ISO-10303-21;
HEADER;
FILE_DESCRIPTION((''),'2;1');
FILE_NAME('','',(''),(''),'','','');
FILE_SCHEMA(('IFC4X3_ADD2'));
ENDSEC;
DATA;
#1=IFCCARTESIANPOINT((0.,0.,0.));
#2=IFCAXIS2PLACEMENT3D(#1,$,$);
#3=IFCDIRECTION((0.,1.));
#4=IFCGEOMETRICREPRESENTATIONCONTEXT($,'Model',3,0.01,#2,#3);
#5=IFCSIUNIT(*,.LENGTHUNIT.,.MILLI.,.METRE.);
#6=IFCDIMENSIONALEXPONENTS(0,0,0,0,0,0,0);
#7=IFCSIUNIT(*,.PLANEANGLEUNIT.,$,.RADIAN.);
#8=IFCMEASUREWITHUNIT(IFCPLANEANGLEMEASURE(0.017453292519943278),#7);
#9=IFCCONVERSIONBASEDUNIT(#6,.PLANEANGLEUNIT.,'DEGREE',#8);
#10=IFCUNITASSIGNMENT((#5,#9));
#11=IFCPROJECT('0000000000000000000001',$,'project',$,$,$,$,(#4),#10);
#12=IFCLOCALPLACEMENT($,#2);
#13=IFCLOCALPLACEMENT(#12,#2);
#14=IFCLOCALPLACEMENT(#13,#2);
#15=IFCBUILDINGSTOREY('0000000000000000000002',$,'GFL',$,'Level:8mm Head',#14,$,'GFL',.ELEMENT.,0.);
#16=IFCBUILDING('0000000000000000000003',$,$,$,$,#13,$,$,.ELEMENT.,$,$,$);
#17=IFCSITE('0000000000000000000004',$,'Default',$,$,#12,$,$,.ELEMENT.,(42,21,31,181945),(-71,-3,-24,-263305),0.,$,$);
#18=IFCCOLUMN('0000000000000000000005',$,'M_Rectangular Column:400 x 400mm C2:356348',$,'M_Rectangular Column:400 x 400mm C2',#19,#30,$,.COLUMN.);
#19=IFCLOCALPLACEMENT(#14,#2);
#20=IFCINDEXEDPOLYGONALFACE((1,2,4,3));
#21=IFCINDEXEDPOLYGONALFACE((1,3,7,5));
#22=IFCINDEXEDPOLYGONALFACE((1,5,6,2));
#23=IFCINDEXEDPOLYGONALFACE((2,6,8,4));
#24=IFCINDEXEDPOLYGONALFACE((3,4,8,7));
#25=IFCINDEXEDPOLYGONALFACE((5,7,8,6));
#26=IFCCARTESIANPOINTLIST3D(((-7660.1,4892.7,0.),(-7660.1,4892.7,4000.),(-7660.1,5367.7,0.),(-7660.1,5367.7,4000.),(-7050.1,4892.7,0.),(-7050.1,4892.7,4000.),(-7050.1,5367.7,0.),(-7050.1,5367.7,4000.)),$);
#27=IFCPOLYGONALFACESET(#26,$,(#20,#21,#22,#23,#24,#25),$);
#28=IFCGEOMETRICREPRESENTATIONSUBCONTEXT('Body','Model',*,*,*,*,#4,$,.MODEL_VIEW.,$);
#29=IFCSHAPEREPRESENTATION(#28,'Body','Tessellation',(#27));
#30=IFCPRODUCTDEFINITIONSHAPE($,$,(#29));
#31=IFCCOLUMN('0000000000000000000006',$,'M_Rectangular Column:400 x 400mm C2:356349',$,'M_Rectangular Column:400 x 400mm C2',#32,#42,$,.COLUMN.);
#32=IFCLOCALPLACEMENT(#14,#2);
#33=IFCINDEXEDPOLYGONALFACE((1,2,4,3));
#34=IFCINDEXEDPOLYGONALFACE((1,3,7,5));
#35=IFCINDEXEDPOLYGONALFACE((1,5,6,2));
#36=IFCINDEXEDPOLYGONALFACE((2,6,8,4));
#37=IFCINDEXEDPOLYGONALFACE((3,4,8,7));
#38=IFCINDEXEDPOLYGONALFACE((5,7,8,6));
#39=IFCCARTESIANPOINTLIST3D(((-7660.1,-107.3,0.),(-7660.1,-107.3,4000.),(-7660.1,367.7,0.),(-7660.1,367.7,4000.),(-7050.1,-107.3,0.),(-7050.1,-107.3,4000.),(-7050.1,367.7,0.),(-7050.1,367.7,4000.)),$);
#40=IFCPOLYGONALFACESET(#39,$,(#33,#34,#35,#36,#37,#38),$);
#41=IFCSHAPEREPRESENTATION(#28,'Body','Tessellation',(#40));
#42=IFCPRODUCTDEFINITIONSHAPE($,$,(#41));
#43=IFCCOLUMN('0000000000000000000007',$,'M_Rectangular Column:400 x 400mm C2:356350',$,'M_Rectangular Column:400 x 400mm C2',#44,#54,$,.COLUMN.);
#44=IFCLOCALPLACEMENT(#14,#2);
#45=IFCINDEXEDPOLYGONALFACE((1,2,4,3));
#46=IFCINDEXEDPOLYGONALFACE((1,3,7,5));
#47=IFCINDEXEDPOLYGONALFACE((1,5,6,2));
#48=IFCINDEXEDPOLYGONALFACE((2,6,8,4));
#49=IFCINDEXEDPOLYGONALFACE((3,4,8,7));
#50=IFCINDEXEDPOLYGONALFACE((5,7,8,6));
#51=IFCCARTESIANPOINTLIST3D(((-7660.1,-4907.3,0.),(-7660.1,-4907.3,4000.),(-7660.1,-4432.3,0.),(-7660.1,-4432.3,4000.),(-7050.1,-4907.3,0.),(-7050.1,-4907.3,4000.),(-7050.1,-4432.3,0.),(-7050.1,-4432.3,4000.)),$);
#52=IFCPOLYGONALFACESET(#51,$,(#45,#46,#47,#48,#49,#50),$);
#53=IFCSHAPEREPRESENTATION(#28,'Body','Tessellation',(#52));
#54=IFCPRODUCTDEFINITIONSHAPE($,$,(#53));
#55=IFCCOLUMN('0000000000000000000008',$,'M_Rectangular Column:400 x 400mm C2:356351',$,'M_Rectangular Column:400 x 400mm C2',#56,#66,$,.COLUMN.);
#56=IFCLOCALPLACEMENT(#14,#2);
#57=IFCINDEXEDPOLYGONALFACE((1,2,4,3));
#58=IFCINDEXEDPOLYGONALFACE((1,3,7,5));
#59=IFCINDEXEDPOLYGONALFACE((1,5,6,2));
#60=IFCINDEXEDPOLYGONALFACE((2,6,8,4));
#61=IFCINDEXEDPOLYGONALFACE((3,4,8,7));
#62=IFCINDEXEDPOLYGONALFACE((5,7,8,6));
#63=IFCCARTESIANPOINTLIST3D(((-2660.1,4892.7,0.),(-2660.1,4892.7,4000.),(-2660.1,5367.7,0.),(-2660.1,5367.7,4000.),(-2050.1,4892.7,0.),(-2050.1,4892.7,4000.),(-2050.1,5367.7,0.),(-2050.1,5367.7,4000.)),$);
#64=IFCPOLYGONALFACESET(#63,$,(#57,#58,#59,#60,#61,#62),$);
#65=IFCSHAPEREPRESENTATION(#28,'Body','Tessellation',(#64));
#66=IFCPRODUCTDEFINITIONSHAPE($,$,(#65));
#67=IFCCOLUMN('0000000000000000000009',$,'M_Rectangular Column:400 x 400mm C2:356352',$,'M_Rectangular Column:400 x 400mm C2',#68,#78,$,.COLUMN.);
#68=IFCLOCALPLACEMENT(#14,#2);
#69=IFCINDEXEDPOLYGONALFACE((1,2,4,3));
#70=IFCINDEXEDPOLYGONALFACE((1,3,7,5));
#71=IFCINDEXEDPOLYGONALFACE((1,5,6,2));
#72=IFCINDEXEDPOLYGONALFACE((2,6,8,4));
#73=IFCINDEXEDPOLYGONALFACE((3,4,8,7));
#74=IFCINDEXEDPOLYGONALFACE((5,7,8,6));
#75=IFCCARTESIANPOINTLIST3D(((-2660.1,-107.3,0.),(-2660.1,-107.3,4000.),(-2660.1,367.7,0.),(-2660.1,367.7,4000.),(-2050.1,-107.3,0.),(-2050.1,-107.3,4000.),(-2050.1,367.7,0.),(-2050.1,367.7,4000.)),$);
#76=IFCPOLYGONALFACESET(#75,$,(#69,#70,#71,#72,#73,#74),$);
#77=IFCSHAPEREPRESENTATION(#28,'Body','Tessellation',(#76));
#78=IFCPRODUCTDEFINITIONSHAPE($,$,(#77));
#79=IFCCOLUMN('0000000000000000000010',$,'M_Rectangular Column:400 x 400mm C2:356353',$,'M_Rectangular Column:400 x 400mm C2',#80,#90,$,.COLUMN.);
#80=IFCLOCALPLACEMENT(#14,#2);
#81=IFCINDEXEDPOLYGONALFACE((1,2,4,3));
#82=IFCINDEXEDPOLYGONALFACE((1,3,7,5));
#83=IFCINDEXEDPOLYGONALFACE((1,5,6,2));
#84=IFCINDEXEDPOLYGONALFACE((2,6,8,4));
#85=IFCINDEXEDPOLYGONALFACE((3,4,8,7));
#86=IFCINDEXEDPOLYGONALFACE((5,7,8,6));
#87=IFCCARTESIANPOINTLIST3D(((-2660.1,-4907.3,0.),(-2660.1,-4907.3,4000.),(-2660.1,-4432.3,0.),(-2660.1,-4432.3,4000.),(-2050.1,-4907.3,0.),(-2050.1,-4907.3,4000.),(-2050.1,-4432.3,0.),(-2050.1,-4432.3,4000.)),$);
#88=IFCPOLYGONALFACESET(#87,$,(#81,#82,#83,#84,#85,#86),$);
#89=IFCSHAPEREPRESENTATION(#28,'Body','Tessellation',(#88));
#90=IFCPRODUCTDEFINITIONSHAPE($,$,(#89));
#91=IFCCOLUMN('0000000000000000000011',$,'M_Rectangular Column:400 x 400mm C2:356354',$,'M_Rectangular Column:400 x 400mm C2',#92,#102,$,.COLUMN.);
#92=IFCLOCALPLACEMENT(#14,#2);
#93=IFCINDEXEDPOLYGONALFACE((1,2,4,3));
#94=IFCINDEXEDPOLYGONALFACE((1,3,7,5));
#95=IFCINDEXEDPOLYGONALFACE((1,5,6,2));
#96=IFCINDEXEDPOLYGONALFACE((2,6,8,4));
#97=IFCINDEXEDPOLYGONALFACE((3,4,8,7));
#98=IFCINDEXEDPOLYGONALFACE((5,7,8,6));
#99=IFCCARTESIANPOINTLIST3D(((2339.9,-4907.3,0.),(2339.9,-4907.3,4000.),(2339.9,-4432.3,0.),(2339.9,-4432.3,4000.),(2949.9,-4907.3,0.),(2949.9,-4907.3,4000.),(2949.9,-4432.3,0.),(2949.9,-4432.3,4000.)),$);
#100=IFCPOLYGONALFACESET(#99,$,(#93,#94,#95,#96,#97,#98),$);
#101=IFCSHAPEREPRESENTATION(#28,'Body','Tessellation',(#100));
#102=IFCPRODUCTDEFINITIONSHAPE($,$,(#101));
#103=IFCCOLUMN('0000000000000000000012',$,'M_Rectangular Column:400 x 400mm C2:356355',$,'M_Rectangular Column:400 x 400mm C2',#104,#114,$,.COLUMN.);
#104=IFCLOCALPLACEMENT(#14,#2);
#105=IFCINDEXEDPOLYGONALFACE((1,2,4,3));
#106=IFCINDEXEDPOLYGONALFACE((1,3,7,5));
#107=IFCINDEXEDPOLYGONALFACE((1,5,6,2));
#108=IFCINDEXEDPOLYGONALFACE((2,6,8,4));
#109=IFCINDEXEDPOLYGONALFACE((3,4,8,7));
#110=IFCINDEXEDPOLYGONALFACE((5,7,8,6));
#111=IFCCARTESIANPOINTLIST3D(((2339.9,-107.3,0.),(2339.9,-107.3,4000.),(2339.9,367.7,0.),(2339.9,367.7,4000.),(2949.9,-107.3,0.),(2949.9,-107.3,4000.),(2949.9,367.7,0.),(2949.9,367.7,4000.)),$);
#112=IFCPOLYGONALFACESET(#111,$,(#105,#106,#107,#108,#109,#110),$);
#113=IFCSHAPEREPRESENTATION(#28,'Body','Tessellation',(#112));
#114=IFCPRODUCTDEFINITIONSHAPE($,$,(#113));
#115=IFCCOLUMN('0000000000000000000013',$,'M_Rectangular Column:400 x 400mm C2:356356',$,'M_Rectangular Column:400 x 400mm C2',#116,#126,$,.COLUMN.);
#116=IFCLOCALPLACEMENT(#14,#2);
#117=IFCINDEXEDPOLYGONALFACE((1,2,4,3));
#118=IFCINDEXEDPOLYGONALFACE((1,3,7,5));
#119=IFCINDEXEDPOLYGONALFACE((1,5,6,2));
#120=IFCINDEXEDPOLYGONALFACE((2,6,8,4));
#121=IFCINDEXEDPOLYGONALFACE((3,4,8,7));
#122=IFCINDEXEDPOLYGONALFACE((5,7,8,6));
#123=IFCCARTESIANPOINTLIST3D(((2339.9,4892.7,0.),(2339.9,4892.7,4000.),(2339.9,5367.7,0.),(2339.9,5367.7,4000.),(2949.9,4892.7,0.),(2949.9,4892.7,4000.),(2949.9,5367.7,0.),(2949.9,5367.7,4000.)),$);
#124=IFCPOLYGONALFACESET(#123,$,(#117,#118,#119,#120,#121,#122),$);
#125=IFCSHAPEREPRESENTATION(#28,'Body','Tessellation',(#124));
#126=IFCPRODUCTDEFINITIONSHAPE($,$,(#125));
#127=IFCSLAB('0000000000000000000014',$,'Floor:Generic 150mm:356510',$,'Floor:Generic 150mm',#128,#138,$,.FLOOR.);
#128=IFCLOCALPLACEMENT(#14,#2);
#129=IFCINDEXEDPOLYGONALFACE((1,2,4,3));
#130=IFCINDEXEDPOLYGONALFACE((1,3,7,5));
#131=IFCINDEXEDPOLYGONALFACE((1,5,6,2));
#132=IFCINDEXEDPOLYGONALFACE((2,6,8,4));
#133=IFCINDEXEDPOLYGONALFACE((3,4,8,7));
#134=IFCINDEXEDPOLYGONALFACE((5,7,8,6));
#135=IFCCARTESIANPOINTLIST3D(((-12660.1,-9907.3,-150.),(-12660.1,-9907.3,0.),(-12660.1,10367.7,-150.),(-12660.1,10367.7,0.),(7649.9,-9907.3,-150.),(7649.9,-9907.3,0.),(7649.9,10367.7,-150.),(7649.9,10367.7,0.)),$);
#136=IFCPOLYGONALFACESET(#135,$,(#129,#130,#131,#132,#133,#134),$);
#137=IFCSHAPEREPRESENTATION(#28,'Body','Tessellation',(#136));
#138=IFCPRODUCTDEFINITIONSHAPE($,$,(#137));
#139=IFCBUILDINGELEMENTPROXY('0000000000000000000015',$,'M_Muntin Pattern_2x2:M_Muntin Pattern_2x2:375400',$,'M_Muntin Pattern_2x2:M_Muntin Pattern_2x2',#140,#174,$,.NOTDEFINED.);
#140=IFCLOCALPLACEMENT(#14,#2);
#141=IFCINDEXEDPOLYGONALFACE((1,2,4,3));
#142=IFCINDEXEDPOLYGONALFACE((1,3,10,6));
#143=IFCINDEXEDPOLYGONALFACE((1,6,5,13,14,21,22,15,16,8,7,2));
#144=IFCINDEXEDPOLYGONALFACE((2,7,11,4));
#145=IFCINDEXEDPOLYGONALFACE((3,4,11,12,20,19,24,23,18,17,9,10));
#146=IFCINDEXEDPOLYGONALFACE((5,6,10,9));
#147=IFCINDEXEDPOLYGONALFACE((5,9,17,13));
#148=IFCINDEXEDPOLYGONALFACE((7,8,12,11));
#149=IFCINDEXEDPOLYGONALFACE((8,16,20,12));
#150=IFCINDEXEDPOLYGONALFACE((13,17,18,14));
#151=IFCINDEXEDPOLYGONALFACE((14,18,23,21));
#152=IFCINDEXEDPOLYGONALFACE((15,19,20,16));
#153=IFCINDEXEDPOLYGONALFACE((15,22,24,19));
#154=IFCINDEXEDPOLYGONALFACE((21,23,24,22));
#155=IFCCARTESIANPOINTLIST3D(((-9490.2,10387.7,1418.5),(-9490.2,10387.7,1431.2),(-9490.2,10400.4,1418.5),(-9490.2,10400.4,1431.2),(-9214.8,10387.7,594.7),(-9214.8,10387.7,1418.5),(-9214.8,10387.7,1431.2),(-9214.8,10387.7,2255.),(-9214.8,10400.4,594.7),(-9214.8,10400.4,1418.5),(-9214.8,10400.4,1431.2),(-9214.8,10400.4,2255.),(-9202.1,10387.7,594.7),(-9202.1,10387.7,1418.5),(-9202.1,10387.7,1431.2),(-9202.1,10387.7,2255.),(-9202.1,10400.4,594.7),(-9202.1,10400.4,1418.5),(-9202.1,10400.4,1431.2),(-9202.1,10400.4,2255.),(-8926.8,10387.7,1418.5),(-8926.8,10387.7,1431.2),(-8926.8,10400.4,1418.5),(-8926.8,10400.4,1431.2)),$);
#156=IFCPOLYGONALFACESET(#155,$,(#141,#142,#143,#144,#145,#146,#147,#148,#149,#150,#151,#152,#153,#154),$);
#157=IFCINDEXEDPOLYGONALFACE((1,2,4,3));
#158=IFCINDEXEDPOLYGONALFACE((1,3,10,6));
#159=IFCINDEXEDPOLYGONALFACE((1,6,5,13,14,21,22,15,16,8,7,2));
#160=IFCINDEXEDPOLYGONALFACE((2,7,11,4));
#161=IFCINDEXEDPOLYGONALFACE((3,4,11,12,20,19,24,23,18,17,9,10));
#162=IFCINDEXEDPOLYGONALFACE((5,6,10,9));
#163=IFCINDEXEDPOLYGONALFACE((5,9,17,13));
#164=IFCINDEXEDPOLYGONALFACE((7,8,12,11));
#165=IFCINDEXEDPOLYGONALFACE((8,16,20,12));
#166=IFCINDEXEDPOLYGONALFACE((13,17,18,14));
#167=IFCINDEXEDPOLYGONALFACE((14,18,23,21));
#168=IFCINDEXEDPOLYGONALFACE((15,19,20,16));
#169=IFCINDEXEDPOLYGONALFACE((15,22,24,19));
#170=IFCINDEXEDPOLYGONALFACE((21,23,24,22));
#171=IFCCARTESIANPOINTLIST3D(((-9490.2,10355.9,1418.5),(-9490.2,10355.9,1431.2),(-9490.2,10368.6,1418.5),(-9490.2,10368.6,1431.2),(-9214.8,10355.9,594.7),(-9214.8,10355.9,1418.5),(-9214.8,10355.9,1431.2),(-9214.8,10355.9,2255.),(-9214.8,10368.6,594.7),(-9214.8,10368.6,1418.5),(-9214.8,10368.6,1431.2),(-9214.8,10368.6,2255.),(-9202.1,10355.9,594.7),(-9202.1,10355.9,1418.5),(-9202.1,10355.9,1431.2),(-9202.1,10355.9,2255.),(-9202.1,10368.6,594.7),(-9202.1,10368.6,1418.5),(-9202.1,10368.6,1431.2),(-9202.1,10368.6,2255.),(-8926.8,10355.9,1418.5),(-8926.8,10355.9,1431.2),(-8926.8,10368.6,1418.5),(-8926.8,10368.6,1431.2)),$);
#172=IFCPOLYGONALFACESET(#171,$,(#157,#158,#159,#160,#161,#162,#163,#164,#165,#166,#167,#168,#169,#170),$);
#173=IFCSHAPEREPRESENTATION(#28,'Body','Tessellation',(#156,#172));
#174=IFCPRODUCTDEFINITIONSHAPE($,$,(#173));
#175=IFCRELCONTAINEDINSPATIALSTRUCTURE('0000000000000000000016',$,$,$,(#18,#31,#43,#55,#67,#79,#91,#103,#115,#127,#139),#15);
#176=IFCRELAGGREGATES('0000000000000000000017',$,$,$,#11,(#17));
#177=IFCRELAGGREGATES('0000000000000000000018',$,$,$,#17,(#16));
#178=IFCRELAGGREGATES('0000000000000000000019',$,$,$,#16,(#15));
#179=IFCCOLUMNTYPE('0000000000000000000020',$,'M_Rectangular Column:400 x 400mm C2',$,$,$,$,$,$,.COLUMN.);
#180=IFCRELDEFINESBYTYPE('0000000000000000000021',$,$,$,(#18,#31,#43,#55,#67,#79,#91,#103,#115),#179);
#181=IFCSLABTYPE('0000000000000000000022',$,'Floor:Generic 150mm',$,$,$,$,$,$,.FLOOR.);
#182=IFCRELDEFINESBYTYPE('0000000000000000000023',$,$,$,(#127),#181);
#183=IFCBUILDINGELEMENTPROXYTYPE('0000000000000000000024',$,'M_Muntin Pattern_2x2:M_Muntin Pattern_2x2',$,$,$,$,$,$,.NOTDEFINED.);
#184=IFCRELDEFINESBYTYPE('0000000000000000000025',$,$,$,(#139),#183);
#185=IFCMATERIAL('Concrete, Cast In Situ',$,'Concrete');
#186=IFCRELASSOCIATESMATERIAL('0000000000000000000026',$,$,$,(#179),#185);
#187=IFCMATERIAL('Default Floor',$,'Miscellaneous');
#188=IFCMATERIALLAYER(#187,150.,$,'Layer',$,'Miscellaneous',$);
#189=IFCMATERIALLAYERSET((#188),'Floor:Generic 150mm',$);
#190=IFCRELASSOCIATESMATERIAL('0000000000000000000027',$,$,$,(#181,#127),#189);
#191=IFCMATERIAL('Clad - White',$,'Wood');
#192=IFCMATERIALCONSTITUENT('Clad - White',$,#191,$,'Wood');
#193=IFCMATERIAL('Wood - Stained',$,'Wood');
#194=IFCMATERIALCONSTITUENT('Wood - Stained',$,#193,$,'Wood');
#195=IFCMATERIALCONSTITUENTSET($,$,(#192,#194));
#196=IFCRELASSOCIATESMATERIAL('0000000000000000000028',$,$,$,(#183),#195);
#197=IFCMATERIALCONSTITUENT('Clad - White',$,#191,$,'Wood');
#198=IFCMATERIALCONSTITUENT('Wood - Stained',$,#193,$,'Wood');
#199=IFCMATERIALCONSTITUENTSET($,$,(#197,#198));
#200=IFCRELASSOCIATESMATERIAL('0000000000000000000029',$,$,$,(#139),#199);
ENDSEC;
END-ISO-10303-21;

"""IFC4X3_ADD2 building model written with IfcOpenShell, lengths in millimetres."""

from ifc_helpers import new_model, entity, si_unit, converted_unit, direction, frame, origin, origin_2d_with_axis, place, context, subcontext, project, spatial, polyline, rectangle, outline, extrude, source, transform, mapped, material, layer, layer_set, layer_usage, constituent, constituent_set, material_profile, profile_set, type_object, type_shapes, element, save


model = new_model("IFC4X3_ADD2")

# Units and contexts
model_context = context("Model", 3, precision=0.01, world=origin(), true_north=direction((0.0, 1.0)))
body_context = subcontext(model_context, "Body", "Model", "MODEL_VIEW")
ifc_project = project(units=[si_unit("LENGTHUNIT", "METRE", prefix="MILLI"), converted_unit("PLANEANGLEUNIT", "DEGREE", entity("IfcPlaneAngleMeasure", 0.017453292519943278), si_unit("PLANEANGLEUNIT", "RADIAN"), dimensions=[0, 0, 0, 0, 0, 0, 0])], contexts=[model_context])

# Site, building, storey
site_placement = place(None, origin())
site = spatial("IfcSite", under=ifc_project, at=site_placement, Name="Default", CompositionType="ELEMENT", RefLatitude=(42, 21, 31, 181945), RefLongitude=(-71, -3, -24, -263305), RefElevation=0.0)
building_placement = place(site_placement, origin())
building = spatial("IfcBuilding", under=site, at=building_placement, CompositionType="ELEMENT")
storey_placement = place(building_placement, origin())
storey = spatial("IfcBuildingStorey", under=building, at=storey_placement, Name="GFL", ObjectType="Level:8mm Head", LongName="GFL", CompositionType="ELEMENT", Elevation=0.0)

# Columns
ifc_material_1 = material(Name="Concrete, Cast In Situ", Category="Concrete")
ifc_material_profile_1 = material_profile(ifc_material_1, rectangle(XDim=610.0, YDim=475.0, at=origin_2d_with_axis()), Name="400 x 400mm C2")
ifc_profile_set_1 = profile_set([ifc_material_profile_1], Name="400 x 400mm C2")
column_type_1 = type_object("IfcColumnType", Name="M_Rectangular Column:400 x 400mm C2", PredefinedType="COLUMN", material=ifc_profile_set_1)
shared_shape_1 = source(origin(), body_context, "Body", "SweptSolid", [
    extrude(rectangle(XDim=610.0, YDim=475.0, at=origin_2d_with_axis()), frame((0.0, 0.0, 0.0), z_axis=(0.0, 0.0, 1.0), x_axis=(-1.0, 0.0, 0.0)), (0.0, 0.0, 1.0), 4000.0),
])
type_shapes(column_type_1, [shared_shape_1])
for number, where, name in (
    (1, (-7355.1, 5130.2, 0.0), "M_Rectangular Column:400 x 400mm C2:356348"),
    (2, (-7355.1, 130.2, 0.0), "M_Rectangular Column:400 x 400mm C2:356349"),
    (3, (-7355.1, -4669.8, 0.0), "M_Rectangular Column:400 x 400mm C2:356350"),
    (4, (-2355.1, 5130.2, 0.0), "M_Rectangular Column:400 x 400mm C2:356351"),
    (5, (-2355.1, 130.2, 0.0), "M_Rectangular Column:400 x 400mm C2:356352"),
    (6, (-2355.1, -4669.8, 0.0), "M_Rectangular Column:400 x 400mm C2:356353"),
    (7, (2644.9, -4669.8, 0.0), "M_Rectangular Column:400 x 400mm C2:356354"),
    (8, (2644.9, 130.2, 0.0), "M_Rectangular Column:400 x 400mm C2:356355"),
    (9, (2644.9, 5130.2, 0.0), "M_Rectangular Column:400 x 400mm C2:356356"),
):
    element("IfcColumn", number, at=place(storey_placement, frame(where)), inside=storey, type_object=column_type_1, Name=name, ObjectType="M_Rectangular Column:400 x 400mm C2", PredefinedType="COLUMN", context=body_context, shape_type="MappedRepresentation", body=[
        mapped(shared_shape_1, transform((0.0, 0.0, 0.0), scale=1.0)),
    ])

# Slab
ifc_material_2 = material(Name="Default Floor", Category="Miscellaneous")
ifc_layer = layer(ifc_material_2, 150.0, Name="Layer", Category="Miscellaneous")
ifc_layer_set = layer_set([ifc_layer], Name="Floor:Generic 150mm")
ifc_layer_usage = layer_usage(ifc_layer_set, "AXIS3", "POSITIVE", 0.0)
slab_type = type_object("IfcSlabType", Name="Floor:Generic 150mm", PredefinedType="FLOOR", material=ifc_layer_set)
slab_placement = place(storey_placement, origin())
element("IfcSlab", 10, at=slab_placement, inside=storey, type_object=slab_type, material=ifc_layer_usage, Name="Floor:Generic 150mm:356510", ObjectType="Floor:Generic 150mm", PredefinedType="FLOOR", context=body_context, shape_type="SweptSolid", body=[
    extrude(rectangle(XDim=20275.0, YDim=20310.0, at=origin_2d_with_axis()), frame((-2505.1, 230.2, 0.0), z_axis=(0.0, 0.0, -1.0), x_axis=(0.0, 1.0, 0.0)), (0.0, 0.0, 1.0), 150.0),
])

# Building element proxy
ifc_material_3 = material(Name="Clad - White", Category="Wood")
ifc_constituent_1 = constituent(ifc_material_3, Name="Clad - White", Category="Wood")
ifc_material_4 = material(Name="Wood - Stained", Category="Wood")
ifc_constituent_2 = constituent(ifc_material_4, Name="Wood - Stained", Category="Wood")
ifc_constituent_set_1 = constituent_set(constituents=[ifc_constituent_1, ifc_constituent_2])
ifc_constituent_3 = constituent(ifc_material_3, Name="Clad - White", Category="Wood")
ifc_constituent_4 = constituent(ifc_material_4, Name="Wood - Stained", Category="Wood")
ifc_constituent_set_2 = constituent_set(constituents=[ifc_constituent_3, ifc_constituent_4])
building_element_proxy_type_1 = type_object("IfcBuildingElementProxyType", Name="M_Muntin Pattern_2x2:M_Muntin Pattern_2x2", PredefinedType="NOTDEFINED", material=ifc_constituent_set_2)
shared_shape_2 = source(origin(), body_context, "Body", "SweptSolid", [
    extrude(outline(polyline([(6.4, -6.4), (830.1, -6.4), (830.1, 6.3), (6.4, 6.3), (6.4, 281.7), (-6.3, 281.7), (-6.3, 6.3), (-830.2, 6.3), (-830.2, -6.4), (-6.3, -6.4), (-6.3, -281.7), (6.4, -281.7), (6.4, -6.4)])), frame((0.0, 9.5, 830.1), z_axis=(0.0, 1.0, 0.0), x_axis=(0.0, 0.0, 1.0)), (0.0, 0.0, 1.0), 12.7),
    extrude(outline(polyline([(6.4, -6.4), (830.2, -6.4), (830.2, 6.3), (6.4, 6.3), (6.4, 281.7), (-6.3, 281.7), (-6.3, 6.3), (-830.2, 6.3), (-830.2, -6.4), (-6.3, -6.4), (-6.3, -281.7), (6.4, -281.7), (6.4, -6.4)])), frame((0.0, -22.2, 830.2), z_axis=(0.0, 1.0, 0.0), x_axis=(0.0, 0.0, 1.0)), (0.0, 0.0, 1.0), 12.7),
])
type_shapes(building_element_proxy_type_1, [shared_shape_2])
proxy_1_placement = place(storey_placement, frame((-9208.5, 10378.2, 594.7)))
element("IfcBuildingElementProxy", 11, at=proxy_1_placement, inside=storey, type_object=building_element_proxy_type_1, material=ifc_constituent_set_1, Name="M_Muntin Pattern_2x2:M_Muntin Pattern_2x2:375400", ObjectType="M_Muntin Pattern_2x2:M_Muntin Pattern_2x2", PredefinedType="NOTDEFINED", context=body_context, shape_type="MappedRepresentation", body=[
    mapped(shared_shape_2, transform((0.0, 0.0, 0.0), scale=1.0)),
])

save(model, "model.ifc")
